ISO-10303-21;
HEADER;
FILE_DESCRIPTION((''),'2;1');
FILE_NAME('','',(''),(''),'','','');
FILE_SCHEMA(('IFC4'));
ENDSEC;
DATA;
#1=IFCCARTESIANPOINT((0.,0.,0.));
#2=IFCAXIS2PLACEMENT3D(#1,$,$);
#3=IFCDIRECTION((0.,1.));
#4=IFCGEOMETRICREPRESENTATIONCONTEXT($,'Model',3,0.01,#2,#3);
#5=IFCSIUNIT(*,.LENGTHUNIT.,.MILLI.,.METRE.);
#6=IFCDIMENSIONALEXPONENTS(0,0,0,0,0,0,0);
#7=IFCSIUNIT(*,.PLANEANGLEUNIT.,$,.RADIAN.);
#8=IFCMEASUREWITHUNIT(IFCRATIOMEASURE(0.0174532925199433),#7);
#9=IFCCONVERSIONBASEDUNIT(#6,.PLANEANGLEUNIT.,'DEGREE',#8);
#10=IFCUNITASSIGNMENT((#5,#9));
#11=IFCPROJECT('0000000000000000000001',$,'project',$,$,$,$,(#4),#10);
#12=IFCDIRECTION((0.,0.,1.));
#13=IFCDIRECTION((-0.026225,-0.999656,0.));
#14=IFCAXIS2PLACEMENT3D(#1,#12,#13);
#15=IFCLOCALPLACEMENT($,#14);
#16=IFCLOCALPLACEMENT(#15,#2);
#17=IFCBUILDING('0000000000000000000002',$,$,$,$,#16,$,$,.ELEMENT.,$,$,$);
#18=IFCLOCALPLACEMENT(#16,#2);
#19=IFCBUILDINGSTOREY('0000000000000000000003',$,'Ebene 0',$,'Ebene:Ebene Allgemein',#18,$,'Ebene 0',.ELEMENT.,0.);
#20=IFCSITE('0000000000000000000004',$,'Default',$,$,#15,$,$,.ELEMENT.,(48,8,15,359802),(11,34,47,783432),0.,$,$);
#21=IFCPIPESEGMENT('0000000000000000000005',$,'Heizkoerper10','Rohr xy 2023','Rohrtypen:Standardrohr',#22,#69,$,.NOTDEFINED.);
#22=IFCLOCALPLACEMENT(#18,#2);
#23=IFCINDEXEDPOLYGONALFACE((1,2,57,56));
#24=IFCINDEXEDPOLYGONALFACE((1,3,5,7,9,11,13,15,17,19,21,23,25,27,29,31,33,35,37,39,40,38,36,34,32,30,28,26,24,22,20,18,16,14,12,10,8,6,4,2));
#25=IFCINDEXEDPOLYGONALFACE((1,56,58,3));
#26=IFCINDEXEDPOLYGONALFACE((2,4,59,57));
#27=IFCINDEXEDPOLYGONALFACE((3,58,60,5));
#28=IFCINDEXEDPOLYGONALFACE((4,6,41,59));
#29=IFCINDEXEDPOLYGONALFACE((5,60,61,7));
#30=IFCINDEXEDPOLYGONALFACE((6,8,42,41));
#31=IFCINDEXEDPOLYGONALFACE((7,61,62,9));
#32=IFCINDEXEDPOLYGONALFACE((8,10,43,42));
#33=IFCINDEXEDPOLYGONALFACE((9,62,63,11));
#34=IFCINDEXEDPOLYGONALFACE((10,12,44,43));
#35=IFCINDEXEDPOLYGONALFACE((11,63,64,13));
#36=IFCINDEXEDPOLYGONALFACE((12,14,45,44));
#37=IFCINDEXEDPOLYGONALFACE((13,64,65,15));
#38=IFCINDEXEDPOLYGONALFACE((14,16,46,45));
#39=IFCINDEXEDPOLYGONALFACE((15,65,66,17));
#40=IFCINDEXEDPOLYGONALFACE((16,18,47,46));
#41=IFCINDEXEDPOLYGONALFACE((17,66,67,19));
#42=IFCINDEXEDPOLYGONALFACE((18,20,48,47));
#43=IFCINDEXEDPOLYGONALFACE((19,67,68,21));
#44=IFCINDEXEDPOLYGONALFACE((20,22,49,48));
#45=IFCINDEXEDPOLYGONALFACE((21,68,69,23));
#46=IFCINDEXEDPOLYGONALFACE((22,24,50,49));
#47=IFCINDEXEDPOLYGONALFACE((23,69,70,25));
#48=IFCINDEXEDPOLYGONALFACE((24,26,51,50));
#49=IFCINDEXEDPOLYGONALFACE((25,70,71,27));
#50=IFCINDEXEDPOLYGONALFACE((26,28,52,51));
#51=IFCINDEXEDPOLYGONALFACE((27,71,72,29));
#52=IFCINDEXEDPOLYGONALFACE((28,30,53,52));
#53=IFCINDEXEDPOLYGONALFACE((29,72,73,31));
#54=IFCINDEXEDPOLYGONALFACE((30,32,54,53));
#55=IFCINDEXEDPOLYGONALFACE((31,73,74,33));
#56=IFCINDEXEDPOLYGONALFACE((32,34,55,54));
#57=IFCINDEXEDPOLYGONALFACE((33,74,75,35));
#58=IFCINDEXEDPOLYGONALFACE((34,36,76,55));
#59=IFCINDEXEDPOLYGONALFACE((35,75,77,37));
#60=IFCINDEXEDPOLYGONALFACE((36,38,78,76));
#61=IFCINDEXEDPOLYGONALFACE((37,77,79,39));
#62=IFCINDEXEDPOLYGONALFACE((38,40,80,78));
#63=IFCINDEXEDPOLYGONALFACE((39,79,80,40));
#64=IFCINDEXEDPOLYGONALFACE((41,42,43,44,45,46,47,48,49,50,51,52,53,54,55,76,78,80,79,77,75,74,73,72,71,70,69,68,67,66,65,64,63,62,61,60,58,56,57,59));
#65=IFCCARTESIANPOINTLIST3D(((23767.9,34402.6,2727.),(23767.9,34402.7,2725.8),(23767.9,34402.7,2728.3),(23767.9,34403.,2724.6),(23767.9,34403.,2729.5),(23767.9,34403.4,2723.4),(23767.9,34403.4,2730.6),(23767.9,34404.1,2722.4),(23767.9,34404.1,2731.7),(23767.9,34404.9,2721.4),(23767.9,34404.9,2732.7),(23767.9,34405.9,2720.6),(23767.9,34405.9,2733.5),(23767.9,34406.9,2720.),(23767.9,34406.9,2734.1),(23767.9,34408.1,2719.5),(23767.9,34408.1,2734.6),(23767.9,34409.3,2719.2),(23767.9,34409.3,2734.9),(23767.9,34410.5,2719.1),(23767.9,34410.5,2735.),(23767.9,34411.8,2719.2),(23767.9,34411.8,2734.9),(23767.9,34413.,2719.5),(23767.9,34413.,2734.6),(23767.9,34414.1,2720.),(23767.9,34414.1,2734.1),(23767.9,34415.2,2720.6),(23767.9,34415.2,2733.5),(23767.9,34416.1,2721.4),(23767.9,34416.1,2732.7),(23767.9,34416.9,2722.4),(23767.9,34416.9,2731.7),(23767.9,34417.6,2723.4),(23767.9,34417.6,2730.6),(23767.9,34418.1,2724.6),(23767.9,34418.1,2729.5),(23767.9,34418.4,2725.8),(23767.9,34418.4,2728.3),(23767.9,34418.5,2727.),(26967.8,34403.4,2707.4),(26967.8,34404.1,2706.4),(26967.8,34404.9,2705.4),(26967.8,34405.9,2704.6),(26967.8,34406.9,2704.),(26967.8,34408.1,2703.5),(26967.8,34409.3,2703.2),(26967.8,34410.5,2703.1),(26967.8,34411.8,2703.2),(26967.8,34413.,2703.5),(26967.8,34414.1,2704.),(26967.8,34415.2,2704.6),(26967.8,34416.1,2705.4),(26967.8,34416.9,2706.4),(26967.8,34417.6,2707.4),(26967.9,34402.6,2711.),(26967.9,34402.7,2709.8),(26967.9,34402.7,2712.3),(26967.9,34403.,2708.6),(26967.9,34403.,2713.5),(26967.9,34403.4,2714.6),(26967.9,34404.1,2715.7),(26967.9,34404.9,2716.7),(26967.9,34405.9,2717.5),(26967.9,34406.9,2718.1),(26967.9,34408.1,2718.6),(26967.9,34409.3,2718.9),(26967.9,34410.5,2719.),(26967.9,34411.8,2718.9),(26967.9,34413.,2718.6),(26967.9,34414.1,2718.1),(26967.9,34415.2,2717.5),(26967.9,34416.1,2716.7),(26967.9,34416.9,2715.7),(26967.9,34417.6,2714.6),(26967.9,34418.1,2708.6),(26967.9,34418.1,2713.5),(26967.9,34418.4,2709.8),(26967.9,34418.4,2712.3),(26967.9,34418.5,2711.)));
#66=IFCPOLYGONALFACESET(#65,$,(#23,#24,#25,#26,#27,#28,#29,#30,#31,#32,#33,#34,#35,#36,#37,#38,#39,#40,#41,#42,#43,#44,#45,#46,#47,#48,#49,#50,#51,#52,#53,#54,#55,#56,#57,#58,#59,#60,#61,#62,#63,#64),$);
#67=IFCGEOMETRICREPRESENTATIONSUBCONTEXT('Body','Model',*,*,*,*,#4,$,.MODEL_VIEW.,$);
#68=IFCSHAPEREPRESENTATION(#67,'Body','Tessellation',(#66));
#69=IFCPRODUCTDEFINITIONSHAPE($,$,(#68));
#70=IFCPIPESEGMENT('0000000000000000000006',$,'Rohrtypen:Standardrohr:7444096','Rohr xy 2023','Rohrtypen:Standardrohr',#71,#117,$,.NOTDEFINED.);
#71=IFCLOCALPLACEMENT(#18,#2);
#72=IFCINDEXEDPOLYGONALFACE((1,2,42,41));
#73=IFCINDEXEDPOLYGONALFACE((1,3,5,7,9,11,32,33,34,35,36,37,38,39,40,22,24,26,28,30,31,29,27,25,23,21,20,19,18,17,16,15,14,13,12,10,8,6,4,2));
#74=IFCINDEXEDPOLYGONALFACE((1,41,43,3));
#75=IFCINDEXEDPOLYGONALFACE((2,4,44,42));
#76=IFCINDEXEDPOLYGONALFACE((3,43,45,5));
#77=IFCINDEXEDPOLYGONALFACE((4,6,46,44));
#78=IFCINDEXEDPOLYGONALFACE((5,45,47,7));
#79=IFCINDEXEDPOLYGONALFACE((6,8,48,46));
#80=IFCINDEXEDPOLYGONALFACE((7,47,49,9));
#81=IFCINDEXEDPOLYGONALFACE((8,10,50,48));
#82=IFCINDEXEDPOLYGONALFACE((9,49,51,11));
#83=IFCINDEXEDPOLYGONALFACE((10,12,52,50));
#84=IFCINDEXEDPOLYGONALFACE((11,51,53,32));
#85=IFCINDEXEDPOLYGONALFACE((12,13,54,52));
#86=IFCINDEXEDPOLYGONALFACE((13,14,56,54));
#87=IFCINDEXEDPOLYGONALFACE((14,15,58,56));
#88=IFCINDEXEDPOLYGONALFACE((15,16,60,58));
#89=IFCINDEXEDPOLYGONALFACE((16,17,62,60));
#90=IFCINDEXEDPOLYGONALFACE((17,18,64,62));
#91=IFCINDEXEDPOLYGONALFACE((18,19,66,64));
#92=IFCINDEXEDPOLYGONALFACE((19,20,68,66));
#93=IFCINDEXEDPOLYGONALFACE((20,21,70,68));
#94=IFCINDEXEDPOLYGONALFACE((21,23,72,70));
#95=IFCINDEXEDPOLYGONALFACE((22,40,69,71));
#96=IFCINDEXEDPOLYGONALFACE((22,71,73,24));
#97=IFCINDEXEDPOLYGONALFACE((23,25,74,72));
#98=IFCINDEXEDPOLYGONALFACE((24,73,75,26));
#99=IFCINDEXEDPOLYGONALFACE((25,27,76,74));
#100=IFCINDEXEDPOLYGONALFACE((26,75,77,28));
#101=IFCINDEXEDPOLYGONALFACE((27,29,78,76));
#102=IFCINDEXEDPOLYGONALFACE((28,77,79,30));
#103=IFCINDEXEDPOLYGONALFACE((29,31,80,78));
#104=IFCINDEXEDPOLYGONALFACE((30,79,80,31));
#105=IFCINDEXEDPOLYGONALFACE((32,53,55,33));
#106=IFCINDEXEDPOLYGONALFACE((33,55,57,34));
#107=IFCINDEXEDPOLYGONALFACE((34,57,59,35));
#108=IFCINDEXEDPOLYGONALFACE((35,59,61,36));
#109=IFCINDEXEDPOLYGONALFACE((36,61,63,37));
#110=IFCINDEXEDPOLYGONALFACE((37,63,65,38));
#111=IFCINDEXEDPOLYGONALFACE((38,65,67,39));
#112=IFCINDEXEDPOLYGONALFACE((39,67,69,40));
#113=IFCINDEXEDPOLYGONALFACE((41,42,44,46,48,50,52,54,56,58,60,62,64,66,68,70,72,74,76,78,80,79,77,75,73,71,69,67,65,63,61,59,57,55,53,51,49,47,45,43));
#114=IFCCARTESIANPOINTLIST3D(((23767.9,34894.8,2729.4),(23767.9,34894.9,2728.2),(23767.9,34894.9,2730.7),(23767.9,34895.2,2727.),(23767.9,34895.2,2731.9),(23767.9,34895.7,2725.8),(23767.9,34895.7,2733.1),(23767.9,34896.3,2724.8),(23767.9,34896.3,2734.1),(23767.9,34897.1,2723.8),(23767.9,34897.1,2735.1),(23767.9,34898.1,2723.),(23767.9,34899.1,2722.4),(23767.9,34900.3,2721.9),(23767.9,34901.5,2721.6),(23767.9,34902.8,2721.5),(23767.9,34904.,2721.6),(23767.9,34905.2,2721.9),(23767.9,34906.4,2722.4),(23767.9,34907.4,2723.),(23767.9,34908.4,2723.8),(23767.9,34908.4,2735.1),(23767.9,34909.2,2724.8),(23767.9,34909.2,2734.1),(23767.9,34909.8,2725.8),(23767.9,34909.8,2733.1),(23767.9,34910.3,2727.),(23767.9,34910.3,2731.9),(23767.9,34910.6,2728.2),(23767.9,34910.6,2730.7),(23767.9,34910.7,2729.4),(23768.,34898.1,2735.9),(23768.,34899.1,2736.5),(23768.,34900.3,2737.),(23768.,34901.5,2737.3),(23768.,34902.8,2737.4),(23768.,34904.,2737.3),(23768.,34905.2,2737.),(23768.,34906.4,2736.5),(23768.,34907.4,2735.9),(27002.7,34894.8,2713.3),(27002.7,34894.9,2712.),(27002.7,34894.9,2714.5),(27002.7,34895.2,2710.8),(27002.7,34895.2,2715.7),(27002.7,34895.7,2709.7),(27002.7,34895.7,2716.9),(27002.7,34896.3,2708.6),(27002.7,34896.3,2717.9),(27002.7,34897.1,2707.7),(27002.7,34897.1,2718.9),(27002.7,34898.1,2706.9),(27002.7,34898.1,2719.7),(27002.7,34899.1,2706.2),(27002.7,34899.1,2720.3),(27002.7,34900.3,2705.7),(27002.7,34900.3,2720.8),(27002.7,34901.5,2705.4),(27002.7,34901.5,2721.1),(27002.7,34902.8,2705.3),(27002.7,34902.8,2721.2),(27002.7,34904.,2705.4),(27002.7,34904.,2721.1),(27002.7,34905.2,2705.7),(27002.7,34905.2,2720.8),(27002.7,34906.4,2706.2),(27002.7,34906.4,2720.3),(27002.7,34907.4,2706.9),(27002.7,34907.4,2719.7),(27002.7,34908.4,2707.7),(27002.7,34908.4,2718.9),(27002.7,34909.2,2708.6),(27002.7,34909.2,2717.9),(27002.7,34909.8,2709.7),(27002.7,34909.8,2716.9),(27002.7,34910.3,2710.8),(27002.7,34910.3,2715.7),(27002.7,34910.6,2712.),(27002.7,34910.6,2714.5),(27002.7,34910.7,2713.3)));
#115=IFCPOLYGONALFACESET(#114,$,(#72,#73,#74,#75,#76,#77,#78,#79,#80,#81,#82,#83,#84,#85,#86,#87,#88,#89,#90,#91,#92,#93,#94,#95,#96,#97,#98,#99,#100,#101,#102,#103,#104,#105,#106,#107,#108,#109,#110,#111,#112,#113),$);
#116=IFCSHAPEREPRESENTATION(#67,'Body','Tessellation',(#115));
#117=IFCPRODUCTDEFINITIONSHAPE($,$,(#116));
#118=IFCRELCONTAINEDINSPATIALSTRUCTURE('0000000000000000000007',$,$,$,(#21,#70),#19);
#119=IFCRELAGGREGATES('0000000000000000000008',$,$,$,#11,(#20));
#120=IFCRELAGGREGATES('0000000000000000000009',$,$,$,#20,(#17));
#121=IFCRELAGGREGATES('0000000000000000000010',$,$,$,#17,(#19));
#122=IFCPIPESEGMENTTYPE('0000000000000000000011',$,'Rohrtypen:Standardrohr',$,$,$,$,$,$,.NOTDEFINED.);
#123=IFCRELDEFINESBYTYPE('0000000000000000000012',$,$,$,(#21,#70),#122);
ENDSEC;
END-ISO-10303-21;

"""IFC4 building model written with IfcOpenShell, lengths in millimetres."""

from ifc_helpers import new_model, entity, si_unit, converted_unit, direction, frame, origin, place, context, subcontext, project, spatial, indexed_curve, outline, extrude, type_object, element, save


model = new_model("IFC4")

# Units and contexts
model_context = context("Model", 3, precision=0.01, world=origin(), true_north=direction((0.0, 1.0)))
body_context = subcontext(model_context, "Body", "Model", "MODEL_VIEW")
ifc_project = project(units=[si_unit("LENGTHUNIT", "METRE", prefix="MILLI"), converted_unit("PLANEANGLEUNIT", "DEGREE", entity("IfcRatioMeasure", 0.0174532925199433), si_unit("PLANEANGLEUNIT", "RADIAN"), dimensions=[0, 0, 0, 0, 0, 0, 0])], contexts=[model_context])

# Site, building, storey
site_placement = place(None, frame((0.0, 0.0, 0.0), z_axis=(0.0, 0.0, 1.0), x_axis=(-0.026225, -0.999656, 0.0)))
site = spatial("IfcSite", under=ifc_project, at=site_placement, Name="Default", CompositionType="ELEMENT", RefLatitude=(48, 8, 15, 359802), RefLongitude=(11, 34, 47, 783432), RefElevation=0.0)
building_placement = place(site_placement, origin())
building = spatial("IfcBuilding", under=site, at=building_placement, CompositionType="ELEMENT")
storey_placement = place(building_placement, origin())
storey = spatial("IfcBuildingStorey", under=building, at=storey_placement, Name="Ebene 0", ObjectType="Ebene:Ebene Allgemein", LongName="Ebene 0", CompositionType="ELEMENT", Elevation=0.0)

# Pipe segments
pipe_segment_type = type_object("IfcPipeSegmentType", Name="Rohrtypen:Standardrohr", PredefinedType="NOTDEFINED")
pipe_segment_1_placement = place(storey_placement, origin())
element("IfcPipeSegment", 1, at=pipe_segment_1_placement, inside=storey, type_object=pipe_segment_type, Name="Heizkoerper10", Description="Rohr xy 2023", ObjectType="Rohrtypen:Standardrohr", PredefinedType="NOTDEFINED", context=body_context, shape_type="SweptSolid", body=[
    extrude(outline(indexed_curve([(7.9, 0.0), (7.8, 1.2), (7.6, 2.5), (7.1, 3.6), (6.4, 4.7), (5.6, 5.6), (4.7, 6.4), (3.6, 7.1), (2.5, 7.6), (1.2, 7.8), (0.0, 7.9), (-1.2, 7.8), (-2.5, 7.6), (-3.6, 7.1), (-4.7, 6.4), (-5.6, 5.6), (-6.4, 4.7), (-7.1, 3.6), (-7.6, 2.5), (-7.8, 1.2), (-7.9, 0.0), (-7.8, -1.2), (-7.6, -2.5), (-7.1, -3.6), (-6.4, -4.7), (-5.6, -5.6), (-4.7, -6.4), (-3.6, -7.1), (-2.5, -7.6), (-1.2, -7.8), (0.0, -7.9), (1.2, -7.8), (2.5, -7.6), (3.6, -7.1), (4.7, -6.4), (5.6, -5.6), (6.4, -4.7), (7.1, -3.6), (7.6, -2.5), (7.8, -1.2), (7.9, 0.0)], self_intersect=False)), frame((26967.9, 34410.5, 2711.0), z_axis=(-0.999988, 0.0, 0.005), x_axis=(0.0, 1.0, 0.0)), (0.0, 0.0, 1.0), 3200.0),
])
pipe_segment_2_placement = place(storey_placement, origin())
element("IfcPipeSegment", 2, at=pipe_segment_2_placement, inside=storey, type_object=pipe_segment_type, Name="Rohrtypen:Standardrohr:7444096", Description="Rohr xy 2023", ObjectType="Rohrtypen:Standardrohr", PredefinedType="NOTDEFINED", context=body_context, shape_type="SweptSolid", body=[
    extrude(outline(indexed_curve([(7.9, 0.0), (7.8, 1.2), (7.6, 2.5), (7.1, 3.6), (6.4, 4.7), (5.6, 5.6), (4.7, 6.4), (3.6, 7.1), (2.5, 7.6), (1.2, 7.8), (0.0, 7.9), (-1.2, 7.8), (-2.5, 7.6), (-3.6, 7.1), (-4.7, 6.4), (-5.6, 5.6), (-6.4, 4.7), (-7.1, 3.6), (-7.6, 2.5), (-7.8, 1.2), (-7.9, 0.0), (-7.8, -1.2), (-7.6, -2.5), (-7.1, -3.6), (-6.4, -4.7), (-5.6, -5.6), (-4.7, -6.4), (-3.6, -7.1), (-2.5, -7.6), (-1.2, -7.8), (0.0, -7.9), (1.2, -7.8), (2.5, -7.6), (3.6, -7.1), (4.7, -6.4), (5.6, -5.6), (6.4, -4.7), (7.1, -3.6), (7.6, -2.5), (7.8, -1.2), (7.9, 0.0)], self_intersect=False)), frame((27002.7, 34902.8, 2713.3), z_axis=(-0.999988, 0.0, 0.005), x_axis=(0.0, 1.0, 0.0)), (0.0, 0.0, 1.0), 3234.8),
])

save(model, "model.ifc")
